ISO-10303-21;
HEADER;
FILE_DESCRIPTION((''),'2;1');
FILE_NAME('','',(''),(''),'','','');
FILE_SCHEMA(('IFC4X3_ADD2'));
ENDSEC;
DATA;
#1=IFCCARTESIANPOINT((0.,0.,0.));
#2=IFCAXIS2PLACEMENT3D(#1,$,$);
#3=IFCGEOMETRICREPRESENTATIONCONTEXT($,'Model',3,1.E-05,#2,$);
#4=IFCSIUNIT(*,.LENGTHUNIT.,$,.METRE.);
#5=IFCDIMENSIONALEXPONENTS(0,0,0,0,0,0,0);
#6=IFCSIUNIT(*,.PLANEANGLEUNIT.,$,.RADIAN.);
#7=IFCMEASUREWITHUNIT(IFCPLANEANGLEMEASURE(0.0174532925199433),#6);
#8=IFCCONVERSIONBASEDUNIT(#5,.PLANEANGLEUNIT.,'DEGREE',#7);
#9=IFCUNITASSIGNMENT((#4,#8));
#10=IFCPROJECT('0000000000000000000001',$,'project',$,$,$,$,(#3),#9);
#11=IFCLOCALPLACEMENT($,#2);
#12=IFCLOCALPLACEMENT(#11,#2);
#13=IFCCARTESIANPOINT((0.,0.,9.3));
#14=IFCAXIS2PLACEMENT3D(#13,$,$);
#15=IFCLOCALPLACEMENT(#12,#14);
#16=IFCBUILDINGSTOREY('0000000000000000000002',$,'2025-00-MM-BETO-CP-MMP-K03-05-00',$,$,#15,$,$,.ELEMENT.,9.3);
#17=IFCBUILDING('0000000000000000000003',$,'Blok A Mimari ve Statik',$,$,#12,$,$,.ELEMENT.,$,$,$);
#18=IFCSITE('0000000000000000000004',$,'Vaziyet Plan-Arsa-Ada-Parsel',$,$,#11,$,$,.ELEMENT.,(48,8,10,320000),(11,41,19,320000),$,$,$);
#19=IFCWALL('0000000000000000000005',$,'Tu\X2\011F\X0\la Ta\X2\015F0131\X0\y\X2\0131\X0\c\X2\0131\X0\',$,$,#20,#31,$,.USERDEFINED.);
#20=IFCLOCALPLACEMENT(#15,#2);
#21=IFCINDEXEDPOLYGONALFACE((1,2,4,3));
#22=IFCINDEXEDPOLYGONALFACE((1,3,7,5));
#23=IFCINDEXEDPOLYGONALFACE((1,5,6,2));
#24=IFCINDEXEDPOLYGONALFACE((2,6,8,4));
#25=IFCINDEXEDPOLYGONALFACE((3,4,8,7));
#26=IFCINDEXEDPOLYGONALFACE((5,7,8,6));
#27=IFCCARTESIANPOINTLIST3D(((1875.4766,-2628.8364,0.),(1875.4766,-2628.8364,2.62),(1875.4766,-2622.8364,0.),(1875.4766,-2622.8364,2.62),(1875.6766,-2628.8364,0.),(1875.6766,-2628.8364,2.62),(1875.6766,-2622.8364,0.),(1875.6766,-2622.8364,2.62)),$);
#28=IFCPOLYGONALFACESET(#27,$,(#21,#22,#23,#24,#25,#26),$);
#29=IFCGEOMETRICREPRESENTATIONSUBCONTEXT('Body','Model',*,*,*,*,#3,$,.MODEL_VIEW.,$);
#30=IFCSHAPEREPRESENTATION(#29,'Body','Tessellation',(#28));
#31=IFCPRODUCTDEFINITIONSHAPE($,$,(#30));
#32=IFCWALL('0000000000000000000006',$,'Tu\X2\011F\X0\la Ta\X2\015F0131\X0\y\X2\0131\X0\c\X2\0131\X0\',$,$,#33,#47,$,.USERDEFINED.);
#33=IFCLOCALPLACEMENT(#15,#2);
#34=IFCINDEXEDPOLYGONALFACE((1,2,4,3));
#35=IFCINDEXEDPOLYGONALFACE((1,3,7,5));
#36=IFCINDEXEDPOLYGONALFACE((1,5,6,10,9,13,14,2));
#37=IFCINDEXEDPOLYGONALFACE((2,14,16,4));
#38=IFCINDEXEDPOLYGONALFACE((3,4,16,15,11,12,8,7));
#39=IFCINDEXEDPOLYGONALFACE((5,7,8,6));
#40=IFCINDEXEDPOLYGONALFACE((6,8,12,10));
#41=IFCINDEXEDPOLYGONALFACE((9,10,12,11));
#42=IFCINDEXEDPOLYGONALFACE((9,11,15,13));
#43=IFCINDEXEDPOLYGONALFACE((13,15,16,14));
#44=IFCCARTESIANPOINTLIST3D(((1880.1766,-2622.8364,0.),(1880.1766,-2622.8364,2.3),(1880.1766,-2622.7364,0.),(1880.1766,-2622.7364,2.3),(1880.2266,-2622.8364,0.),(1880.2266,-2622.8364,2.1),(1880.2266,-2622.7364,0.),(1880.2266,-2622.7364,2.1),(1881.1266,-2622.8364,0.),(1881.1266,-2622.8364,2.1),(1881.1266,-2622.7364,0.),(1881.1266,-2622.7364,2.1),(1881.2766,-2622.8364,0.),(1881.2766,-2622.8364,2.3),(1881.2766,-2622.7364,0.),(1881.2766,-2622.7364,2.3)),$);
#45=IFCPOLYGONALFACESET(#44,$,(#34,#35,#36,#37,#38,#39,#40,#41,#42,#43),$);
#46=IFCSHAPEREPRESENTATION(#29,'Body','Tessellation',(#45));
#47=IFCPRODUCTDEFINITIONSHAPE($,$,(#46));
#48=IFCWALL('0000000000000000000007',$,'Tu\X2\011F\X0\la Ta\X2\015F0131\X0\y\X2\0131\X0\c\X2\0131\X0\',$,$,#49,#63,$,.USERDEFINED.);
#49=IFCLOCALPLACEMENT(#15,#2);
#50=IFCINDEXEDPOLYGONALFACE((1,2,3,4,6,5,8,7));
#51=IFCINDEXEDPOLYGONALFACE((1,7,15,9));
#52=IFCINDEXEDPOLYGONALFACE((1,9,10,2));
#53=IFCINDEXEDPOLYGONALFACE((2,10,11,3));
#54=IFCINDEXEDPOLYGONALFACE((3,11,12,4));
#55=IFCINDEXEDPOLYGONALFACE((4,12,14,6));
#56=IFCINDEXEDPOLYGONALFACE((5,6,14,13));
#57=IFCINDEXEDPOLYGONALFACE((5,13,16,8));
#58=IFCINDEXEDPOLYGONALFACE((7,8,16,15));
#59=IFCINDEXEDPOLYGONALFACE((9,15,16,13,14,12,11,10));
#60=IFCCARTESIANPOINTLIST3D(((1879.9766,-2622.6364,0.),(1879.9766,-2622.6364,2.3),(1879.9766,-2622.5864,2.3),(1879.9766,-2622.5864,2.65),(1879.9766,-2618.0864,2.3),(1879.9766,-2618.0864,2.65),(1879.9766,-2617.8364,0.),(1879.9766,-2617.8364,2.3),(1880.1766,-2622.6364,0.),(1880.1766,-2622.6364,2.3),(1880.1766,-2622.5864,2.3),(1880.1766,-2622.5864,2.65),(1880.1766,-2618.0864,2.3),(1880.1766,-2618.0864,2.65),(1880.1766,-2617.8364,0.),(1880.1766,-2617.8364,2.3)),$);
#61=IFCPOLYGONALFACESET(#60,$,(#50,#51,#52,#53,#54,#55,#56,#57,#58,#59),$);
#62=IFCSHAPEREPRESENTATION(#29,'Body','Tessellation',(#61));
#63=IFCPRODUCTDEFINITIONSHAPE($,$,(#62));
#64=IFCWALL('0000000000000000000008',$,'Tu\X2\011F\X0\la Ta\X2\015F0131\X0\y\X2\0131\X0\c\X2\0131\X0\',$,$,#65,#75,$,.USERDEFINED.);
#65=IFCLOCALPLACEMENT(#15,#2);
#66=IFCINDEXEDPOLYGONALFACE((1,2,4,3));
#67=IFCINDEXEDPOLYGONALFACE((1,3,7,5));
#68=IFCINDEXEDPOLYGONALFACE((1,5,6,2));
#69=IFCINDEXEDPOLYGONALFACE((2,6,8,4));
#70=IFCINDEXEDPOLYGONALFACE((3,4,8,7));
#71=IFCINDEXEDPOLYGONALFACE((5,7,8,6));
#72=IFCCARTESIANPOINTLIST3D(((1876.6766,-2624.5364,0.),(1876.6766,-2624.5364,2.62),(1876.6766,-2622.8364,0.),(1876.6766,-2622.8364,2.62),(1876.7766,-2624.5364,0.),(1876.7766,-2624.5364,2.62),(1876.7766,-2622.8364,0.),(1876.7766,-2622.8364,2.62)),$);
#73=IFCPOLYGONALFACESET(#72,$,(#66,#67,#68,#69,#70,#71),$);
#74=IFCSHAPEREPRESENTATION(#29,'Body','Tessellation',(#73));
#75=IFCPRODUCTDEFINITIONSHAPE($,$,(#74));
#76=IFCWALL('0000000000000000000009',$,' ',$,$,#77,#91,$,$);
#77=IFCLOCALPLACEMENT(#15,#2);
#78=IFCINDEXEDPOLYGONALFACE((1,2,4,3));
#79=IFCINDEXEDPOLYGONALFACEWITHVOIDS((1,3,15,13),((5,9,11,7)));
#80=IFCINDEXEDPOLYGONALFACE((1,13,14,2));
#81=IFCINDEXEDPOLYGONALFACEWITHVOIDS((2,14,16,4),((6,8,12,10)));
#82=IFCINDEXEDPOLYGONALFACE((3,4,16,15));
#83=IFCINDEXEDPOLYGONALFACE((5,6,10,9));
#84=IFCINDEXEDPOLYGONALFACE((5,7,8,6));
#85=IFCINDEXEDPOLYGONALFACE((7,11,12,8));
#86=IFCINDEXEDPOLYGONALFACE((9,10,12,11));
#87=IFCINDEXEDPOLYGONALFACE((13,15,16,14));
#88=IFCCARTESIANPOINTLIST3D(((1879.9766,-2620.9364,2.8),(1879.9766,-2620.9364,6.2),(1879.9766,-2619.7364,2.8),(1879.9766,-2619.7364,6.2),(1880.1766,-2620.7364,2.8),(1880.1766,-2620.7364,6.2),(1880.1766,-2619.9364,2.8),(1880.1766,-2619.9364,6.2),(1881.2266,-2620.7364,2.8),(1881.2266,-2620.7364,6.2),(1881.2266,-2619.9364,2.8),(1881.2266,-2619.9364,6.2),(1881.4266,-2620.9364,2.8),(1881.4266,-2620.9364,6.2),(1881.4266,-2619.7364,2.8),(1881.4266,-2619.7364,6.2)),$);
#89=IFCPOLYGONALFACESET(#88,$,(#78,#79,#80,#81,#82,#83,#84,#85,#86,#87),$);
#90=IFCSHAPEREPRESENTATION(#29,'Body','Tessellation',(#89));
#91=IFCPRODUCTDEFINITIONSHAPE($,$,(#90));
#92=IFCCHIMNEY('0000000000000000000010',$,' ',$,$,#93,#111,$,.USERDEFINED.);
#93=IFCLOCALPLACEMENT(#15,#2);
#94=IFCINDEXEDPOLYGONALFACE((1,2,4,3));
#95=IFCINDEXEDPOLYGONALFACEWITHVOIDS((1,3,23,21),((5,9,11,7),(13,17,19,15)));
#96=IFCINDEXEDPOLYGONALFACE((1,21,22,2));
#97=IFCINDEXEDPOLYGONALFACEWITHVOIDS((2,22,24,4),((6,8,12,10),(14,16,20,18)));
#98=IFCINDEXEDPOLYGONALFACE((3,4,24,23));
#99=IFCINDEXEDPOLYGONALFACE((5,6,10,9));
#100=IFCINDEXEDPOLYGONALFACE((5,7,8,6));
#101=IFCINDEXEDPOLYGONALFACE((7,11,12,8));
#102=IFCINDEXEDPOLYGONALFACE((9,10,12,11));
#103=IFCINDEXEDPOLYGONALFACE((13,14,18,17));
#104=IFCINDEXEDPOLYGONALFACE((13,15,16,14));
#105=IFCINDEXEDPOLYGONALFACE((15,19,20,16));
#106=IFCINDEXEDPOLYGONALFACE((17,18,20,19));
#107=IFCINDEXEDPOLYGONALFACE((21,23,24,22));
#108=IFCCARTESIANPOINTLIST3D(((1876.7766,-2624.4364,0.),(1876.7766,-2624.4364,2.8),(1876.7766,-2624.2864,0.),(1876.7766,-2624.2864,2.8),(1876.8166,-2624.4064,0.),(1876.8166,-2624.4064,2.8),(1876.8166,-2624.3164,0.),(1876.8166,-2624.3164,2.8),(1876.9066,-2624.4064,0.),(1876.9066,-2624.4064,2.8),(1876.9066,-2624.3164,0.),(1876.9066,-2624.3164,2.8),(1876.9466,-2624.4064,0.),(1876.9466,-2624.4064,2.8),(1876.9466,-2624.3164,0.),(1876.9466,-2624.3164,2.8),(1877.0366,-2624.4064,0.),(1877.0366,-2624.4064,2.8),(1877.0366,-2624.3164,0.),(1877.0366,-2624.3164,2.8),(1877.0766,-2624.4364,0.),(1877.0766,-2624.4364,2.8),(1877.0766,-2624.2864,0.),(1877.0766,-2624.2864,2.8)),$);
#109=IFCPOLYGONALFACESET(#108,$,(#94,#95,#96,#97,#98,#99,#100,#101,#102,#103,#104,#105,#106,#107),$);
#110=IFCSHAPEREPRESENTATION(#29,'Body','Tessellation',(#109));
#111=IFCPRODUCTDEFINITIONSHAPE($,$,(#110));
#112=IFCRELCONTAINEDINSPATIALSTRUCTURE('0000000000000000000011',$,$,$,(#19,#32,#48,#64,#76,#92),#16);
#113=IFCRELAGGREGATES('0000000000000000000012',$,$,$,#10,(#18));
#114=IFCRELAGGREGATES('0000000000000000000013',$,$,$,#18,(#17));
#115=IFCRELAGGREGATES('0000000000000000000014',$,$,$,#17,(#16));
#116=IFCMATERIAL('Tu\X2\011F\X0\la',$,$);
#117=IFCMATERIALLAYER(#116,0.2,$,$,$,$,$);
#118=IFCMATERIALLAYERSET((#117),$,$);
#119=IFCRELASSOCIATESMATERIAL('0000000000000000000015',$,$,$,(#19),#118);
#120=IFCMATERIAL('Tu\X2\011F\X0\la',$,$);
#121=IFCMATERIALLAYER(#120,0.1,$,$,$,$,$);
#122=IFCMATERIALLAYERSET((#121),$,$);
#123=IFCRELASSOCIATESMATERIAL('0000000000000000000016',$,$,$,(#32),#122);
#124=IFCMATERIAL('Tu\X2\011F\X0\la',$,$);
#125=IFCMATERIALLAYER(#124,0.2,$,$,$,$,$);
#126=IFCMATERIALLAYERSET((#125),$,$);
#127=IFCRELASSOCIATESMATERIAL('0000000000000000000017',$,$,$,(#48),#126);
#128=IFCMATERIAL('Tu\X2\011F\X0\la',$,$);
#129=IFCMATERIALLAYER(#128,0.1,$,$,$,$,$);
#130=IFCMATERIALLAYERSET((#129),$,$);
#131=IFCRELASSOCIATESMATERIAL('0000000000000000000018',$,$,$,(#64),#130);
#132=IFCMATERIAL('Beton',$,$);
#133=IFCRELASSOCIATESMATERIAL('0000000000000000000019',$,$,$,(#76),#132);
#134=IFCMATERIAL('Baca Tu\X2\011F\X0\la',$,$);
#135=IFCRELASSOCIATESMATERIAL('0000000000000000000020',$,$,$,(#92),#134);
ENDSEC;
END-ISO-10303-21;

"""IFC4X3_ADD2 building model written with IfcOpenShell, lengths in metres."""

from ifc_helpers import new_model, entity, si_unit, converted_unit, frame, frame_2d, origin, origin_with_axes, place, context, subcontext, project, spatial, polyline, rectangle, outline, extrude, clip, bounded_halfspace, material, layer, layer_set, layer_usage, element, save


model = new_model("IFC4X3_ADD2")

# Units and contexts
model_context = context("Model", 3, precision=1e-05, world=origin())
body_context = subcontext(model_context, "Body", "Model", "MODEL_VIEW")
ifc_project = project(units=[si_unit("LENGTHUNIT", "METRE"), converted_unit("PLANEANGLEUNIT", "DEGREE", entity("IfcPlaneAngleMeasure", 0.0174532925199433), si_unit("PLANEANGLEUNIT", "RADIAN"), dimensions=[0, 0, 0, 0, 0, 0, 0])], contexts=[model_context])

# Site, building, storey
site_placement = place(None, origin())
site = spatial("IfcSite", under=ifc_project, at=site_placement, Name="Vaziyet Plan-Arsa-Ada-Parsel", CompositionType="ELEMENT", RefLatitude=(48, 8, 10, 320000), RefLongitude=(11, 41, 19, 320000))
building_placement = place(site_placement, origin())
building = spatial("IfcBuilding", under=site, at=building_placement, Name="Blok A Mimari ve Statik", CompositionType="ELEMENT")
storey_placement = place(building_placement, frame((0.0, 0.0, 9.3)))
storey = spatial("IfcBuildingStorey", under=building, at=storey_placement, Name="2025-00-MM-BETO-CP-MMP-K03-05-00", CompositionType="ELEMENT", Elevation=9.3)

# Wall
ifc_material_1 = material(Name="Tuğla")
ifc_layer_1 = layer(ifc_material_1, 0.2)
ifc_layer_set_1 = layer_set([ifc_layer_1])
ifc_layer_usage_1 = layer_usage(ifc_layer_set_1, "AXIS2", "POSITIVE", 0.0)
wall_1_placement = place(storey_placement, frame((1875.4766, -2622.8364, 0.0), z_axis=(0.0, 0.0, 1.0), x_axis=(0.0, -1.0, 0.0)))
element("IfcWall", 1, at=wall_1_placement, inside=storey, material=ifc_layer_usage_1, Name="Tuğla Taşıyıcı", PredefinedType="USERDEFINED", context=body_context, shape_type="SweptSolid", body=[
    extrude(rectangle(XDim=6.0, YDim=0.2, at=frame_2d((3.0, 0.1), x_axis=(1.0, 0.0))), origin_with_axes(), (0.0, 0.0, 1.0), 2.62),
])

# Wall, opening
ifc_material_2 = material(Name="Tuğla")
ifc_layer_2 = layer(ifc_material_2, 0.1)
ifc_layer_set_2 = layer_set([ifc_layer_2])
ifc_layer_usage_2 = layer_usage(ifc_layer_set_2, "AXIS2", "POSITIVE", 0.0)
wall_2_placement = place(storey_placement, frame((1880.1766, -2622.8364, 0.0), z_axis=(0.0, 0.0, 1.0), x_axis=(1.0, -0.000001, 0.0)))
wall_2 = element("IfcWall", 2, at=wall_2_placement, inside=storey, material=ifc_layer_usage_2, Name="Tuğla Taşıyıcı", PredefinedType="USERDEFINED", context=body_context, shape_type="SweptSolid", body=[
    extrude(rectangle(XDim=1.1, YDim=0.1, at=frame_2d((0.55, 0.05), x_axis=(1.0, 0.0))), origin_with_axes(), (0.0, 0.0, 1.0), 2.3),
])
opening_1_placement = place(wall_2_placement, frame((0.05, 0.0, 0.0), z_axis=(0.0, 1.0, 0.0), x_axis=(0.0, 0.0, 1.0)))
element("IfcOpeningElement", 3, at=opening_1_placement, cuts=wall_2, PredefinedType="OPENING", context=body_context, shape_type="SweptSolid", body=[
    extrude(outline(polyline([(2.1, 0.9), (2.1, 0.0), (0.0, 0.0), (0.0, 0.9), (2.1, 0.9)])), origin_with_axes(), (0.0, 0.0, 1.0), 0.1),
])

# Walls
ifc_material_3 = material(Name="Tuğla")
ifc_layer_3 = layer(ifc_material_3, 0.2)
ifc_layer_set_3 = layer_set([ifc_layer_3])
ifc_layer_usage_3 = layer_usage(ifc_layer_set_3, "AXIS2", "POSITIVE", 0.0)
wall_3_placement = place(storey_placement, frame((1880.1766, -2622.6364, 0.0), z_axis=(0.0, 0.0, 1.0), x_axis=(0.0, 1.0, 0.0)))
element("IfcWall", 4, at=wall_3_placement, inside=storey, material=ifc_layer_usage_3, Name="Tuğla Taşıyıcı", PredefinedType="USERDEFINED", context=body_context, shape_type="Clipping", body=[
    clip(clip(extrude(rectangle(XDim=4.8, YDim=0.2, at=frame_2d((2.4, 0.1), x_axis=(1.0, 0.0))), origin_with_axes(), (0.0, 0.0, 1.0), 2.65), bounded_halfspace(frame((4.675, 0.1, 2.3), z_axis=(0.0, 0.0, -1.0), x_axis=(-1.0, 0.0, 0.0)), True, origin_with_axes(), polyline([(4.8, 0.2), (4.55, 0.2), (4.55, 0.0), (4.8, 0.0), (4.8, 0.2)]))), bounded_halfspace(frame((0.025, 0.1, 2.3), z_axis=(0.0, 0.0, -1.0), x_axis=(0.0, -1.0, 0.0)), True, origin_with_axes(), polyline([(0.0, 0.2), (0.0, 0.0), (0.05, 0.0), (0.05, 0.2), (0.0, 0.2)]))),
])
ifc_material_4 = material(Name="Tuğla")
ifc_layer_4 = layer(ifc_material_4, 0.1)
ifc_layer_set_4 = layer_set([ifc_layer_4])
ifc_layer_usage_4 = layer_usage(ifc_layer_set_4, "AXIS2", "POSITIVE", 0.0)
wall_4_placement = place(storey_placement, frame((1876.6766, -2622.8364, 0.0), z_axis=(0.0, 0.0, 1.0), x_axis=(0.0, -1.0, 0.0)))
element("IfcWall", 5, at=wall_4_placement, inside=storey, material=ifc_layer_usage_4, Name="Tuğla Taşıyıcı", PredefinedType="USERDEFINED", context=body_context, shape_type="SweptSolid", body=[
    extrude(rectangle(XDim=1.7, YDim=0.1, at=frame_2d((0.85, 0.05), x_axis=(1.0, 0.0))), origin_with_axes(), (0.0, 0.0, 1.0), 2.62),
])
ifc_material_5 = material(Name="Beton")
wall_5_placement = place(storey_placement, frame((1879.9766, -2620.9364, 2.8)))
element("IfcWall", 6, at=wall_5_placement, inside=storey, material=ifc_material_5, Name=" ", context=body_context, shape_type="SweptSolid", body=[
    extrude(outline(polyline([(0.0, 0.0), (1.45, 0.0), (1.45, 1.2), (0.0, 1.2), (0.0, 0.0)]), holes=[polyline([(0.2, 0.2), (0.2, 1.0), (1.25, 1.0), (1.25, 0.2), (0.2, 0.2)])]), origin_with_axes(), (0.0, 0.0, 1.0), 3.4),
])

# Chimney
ifc_material_6 = material(Name="Baca Tuğla")
chimney_placement = place(storey_placement, frame((1876.7766, -2624.4364, 0.0)))
element("IfcChimney", 7, at=chimney_placement, inside=storey, material=ifc_material_6, Name=" ", PredefinedType="USERDEFINED", context=body_context, shape_type="SweptSolid", body=[
    extrude(outline(polyline([(0.3, 0.15), (0.0, 0.15), (0.0, 0.0), (0.3, 0.0), (0.3, 0.15)]), holes=[polyline([(0.26, 0.12), (0.26, 0.03), (0.17, 0.03), (0.17, 0.12), (0.26, 0.12)]), polyline([(0.13, 0.12), (0.13, 0.03), (0.04, 0.03), (0.04, 0.12), (0.13, 0.12)])]), origin_with_axes(), (0.0, 0.0, 1.0), 2.8),
])

save(model, "model.ifc")
